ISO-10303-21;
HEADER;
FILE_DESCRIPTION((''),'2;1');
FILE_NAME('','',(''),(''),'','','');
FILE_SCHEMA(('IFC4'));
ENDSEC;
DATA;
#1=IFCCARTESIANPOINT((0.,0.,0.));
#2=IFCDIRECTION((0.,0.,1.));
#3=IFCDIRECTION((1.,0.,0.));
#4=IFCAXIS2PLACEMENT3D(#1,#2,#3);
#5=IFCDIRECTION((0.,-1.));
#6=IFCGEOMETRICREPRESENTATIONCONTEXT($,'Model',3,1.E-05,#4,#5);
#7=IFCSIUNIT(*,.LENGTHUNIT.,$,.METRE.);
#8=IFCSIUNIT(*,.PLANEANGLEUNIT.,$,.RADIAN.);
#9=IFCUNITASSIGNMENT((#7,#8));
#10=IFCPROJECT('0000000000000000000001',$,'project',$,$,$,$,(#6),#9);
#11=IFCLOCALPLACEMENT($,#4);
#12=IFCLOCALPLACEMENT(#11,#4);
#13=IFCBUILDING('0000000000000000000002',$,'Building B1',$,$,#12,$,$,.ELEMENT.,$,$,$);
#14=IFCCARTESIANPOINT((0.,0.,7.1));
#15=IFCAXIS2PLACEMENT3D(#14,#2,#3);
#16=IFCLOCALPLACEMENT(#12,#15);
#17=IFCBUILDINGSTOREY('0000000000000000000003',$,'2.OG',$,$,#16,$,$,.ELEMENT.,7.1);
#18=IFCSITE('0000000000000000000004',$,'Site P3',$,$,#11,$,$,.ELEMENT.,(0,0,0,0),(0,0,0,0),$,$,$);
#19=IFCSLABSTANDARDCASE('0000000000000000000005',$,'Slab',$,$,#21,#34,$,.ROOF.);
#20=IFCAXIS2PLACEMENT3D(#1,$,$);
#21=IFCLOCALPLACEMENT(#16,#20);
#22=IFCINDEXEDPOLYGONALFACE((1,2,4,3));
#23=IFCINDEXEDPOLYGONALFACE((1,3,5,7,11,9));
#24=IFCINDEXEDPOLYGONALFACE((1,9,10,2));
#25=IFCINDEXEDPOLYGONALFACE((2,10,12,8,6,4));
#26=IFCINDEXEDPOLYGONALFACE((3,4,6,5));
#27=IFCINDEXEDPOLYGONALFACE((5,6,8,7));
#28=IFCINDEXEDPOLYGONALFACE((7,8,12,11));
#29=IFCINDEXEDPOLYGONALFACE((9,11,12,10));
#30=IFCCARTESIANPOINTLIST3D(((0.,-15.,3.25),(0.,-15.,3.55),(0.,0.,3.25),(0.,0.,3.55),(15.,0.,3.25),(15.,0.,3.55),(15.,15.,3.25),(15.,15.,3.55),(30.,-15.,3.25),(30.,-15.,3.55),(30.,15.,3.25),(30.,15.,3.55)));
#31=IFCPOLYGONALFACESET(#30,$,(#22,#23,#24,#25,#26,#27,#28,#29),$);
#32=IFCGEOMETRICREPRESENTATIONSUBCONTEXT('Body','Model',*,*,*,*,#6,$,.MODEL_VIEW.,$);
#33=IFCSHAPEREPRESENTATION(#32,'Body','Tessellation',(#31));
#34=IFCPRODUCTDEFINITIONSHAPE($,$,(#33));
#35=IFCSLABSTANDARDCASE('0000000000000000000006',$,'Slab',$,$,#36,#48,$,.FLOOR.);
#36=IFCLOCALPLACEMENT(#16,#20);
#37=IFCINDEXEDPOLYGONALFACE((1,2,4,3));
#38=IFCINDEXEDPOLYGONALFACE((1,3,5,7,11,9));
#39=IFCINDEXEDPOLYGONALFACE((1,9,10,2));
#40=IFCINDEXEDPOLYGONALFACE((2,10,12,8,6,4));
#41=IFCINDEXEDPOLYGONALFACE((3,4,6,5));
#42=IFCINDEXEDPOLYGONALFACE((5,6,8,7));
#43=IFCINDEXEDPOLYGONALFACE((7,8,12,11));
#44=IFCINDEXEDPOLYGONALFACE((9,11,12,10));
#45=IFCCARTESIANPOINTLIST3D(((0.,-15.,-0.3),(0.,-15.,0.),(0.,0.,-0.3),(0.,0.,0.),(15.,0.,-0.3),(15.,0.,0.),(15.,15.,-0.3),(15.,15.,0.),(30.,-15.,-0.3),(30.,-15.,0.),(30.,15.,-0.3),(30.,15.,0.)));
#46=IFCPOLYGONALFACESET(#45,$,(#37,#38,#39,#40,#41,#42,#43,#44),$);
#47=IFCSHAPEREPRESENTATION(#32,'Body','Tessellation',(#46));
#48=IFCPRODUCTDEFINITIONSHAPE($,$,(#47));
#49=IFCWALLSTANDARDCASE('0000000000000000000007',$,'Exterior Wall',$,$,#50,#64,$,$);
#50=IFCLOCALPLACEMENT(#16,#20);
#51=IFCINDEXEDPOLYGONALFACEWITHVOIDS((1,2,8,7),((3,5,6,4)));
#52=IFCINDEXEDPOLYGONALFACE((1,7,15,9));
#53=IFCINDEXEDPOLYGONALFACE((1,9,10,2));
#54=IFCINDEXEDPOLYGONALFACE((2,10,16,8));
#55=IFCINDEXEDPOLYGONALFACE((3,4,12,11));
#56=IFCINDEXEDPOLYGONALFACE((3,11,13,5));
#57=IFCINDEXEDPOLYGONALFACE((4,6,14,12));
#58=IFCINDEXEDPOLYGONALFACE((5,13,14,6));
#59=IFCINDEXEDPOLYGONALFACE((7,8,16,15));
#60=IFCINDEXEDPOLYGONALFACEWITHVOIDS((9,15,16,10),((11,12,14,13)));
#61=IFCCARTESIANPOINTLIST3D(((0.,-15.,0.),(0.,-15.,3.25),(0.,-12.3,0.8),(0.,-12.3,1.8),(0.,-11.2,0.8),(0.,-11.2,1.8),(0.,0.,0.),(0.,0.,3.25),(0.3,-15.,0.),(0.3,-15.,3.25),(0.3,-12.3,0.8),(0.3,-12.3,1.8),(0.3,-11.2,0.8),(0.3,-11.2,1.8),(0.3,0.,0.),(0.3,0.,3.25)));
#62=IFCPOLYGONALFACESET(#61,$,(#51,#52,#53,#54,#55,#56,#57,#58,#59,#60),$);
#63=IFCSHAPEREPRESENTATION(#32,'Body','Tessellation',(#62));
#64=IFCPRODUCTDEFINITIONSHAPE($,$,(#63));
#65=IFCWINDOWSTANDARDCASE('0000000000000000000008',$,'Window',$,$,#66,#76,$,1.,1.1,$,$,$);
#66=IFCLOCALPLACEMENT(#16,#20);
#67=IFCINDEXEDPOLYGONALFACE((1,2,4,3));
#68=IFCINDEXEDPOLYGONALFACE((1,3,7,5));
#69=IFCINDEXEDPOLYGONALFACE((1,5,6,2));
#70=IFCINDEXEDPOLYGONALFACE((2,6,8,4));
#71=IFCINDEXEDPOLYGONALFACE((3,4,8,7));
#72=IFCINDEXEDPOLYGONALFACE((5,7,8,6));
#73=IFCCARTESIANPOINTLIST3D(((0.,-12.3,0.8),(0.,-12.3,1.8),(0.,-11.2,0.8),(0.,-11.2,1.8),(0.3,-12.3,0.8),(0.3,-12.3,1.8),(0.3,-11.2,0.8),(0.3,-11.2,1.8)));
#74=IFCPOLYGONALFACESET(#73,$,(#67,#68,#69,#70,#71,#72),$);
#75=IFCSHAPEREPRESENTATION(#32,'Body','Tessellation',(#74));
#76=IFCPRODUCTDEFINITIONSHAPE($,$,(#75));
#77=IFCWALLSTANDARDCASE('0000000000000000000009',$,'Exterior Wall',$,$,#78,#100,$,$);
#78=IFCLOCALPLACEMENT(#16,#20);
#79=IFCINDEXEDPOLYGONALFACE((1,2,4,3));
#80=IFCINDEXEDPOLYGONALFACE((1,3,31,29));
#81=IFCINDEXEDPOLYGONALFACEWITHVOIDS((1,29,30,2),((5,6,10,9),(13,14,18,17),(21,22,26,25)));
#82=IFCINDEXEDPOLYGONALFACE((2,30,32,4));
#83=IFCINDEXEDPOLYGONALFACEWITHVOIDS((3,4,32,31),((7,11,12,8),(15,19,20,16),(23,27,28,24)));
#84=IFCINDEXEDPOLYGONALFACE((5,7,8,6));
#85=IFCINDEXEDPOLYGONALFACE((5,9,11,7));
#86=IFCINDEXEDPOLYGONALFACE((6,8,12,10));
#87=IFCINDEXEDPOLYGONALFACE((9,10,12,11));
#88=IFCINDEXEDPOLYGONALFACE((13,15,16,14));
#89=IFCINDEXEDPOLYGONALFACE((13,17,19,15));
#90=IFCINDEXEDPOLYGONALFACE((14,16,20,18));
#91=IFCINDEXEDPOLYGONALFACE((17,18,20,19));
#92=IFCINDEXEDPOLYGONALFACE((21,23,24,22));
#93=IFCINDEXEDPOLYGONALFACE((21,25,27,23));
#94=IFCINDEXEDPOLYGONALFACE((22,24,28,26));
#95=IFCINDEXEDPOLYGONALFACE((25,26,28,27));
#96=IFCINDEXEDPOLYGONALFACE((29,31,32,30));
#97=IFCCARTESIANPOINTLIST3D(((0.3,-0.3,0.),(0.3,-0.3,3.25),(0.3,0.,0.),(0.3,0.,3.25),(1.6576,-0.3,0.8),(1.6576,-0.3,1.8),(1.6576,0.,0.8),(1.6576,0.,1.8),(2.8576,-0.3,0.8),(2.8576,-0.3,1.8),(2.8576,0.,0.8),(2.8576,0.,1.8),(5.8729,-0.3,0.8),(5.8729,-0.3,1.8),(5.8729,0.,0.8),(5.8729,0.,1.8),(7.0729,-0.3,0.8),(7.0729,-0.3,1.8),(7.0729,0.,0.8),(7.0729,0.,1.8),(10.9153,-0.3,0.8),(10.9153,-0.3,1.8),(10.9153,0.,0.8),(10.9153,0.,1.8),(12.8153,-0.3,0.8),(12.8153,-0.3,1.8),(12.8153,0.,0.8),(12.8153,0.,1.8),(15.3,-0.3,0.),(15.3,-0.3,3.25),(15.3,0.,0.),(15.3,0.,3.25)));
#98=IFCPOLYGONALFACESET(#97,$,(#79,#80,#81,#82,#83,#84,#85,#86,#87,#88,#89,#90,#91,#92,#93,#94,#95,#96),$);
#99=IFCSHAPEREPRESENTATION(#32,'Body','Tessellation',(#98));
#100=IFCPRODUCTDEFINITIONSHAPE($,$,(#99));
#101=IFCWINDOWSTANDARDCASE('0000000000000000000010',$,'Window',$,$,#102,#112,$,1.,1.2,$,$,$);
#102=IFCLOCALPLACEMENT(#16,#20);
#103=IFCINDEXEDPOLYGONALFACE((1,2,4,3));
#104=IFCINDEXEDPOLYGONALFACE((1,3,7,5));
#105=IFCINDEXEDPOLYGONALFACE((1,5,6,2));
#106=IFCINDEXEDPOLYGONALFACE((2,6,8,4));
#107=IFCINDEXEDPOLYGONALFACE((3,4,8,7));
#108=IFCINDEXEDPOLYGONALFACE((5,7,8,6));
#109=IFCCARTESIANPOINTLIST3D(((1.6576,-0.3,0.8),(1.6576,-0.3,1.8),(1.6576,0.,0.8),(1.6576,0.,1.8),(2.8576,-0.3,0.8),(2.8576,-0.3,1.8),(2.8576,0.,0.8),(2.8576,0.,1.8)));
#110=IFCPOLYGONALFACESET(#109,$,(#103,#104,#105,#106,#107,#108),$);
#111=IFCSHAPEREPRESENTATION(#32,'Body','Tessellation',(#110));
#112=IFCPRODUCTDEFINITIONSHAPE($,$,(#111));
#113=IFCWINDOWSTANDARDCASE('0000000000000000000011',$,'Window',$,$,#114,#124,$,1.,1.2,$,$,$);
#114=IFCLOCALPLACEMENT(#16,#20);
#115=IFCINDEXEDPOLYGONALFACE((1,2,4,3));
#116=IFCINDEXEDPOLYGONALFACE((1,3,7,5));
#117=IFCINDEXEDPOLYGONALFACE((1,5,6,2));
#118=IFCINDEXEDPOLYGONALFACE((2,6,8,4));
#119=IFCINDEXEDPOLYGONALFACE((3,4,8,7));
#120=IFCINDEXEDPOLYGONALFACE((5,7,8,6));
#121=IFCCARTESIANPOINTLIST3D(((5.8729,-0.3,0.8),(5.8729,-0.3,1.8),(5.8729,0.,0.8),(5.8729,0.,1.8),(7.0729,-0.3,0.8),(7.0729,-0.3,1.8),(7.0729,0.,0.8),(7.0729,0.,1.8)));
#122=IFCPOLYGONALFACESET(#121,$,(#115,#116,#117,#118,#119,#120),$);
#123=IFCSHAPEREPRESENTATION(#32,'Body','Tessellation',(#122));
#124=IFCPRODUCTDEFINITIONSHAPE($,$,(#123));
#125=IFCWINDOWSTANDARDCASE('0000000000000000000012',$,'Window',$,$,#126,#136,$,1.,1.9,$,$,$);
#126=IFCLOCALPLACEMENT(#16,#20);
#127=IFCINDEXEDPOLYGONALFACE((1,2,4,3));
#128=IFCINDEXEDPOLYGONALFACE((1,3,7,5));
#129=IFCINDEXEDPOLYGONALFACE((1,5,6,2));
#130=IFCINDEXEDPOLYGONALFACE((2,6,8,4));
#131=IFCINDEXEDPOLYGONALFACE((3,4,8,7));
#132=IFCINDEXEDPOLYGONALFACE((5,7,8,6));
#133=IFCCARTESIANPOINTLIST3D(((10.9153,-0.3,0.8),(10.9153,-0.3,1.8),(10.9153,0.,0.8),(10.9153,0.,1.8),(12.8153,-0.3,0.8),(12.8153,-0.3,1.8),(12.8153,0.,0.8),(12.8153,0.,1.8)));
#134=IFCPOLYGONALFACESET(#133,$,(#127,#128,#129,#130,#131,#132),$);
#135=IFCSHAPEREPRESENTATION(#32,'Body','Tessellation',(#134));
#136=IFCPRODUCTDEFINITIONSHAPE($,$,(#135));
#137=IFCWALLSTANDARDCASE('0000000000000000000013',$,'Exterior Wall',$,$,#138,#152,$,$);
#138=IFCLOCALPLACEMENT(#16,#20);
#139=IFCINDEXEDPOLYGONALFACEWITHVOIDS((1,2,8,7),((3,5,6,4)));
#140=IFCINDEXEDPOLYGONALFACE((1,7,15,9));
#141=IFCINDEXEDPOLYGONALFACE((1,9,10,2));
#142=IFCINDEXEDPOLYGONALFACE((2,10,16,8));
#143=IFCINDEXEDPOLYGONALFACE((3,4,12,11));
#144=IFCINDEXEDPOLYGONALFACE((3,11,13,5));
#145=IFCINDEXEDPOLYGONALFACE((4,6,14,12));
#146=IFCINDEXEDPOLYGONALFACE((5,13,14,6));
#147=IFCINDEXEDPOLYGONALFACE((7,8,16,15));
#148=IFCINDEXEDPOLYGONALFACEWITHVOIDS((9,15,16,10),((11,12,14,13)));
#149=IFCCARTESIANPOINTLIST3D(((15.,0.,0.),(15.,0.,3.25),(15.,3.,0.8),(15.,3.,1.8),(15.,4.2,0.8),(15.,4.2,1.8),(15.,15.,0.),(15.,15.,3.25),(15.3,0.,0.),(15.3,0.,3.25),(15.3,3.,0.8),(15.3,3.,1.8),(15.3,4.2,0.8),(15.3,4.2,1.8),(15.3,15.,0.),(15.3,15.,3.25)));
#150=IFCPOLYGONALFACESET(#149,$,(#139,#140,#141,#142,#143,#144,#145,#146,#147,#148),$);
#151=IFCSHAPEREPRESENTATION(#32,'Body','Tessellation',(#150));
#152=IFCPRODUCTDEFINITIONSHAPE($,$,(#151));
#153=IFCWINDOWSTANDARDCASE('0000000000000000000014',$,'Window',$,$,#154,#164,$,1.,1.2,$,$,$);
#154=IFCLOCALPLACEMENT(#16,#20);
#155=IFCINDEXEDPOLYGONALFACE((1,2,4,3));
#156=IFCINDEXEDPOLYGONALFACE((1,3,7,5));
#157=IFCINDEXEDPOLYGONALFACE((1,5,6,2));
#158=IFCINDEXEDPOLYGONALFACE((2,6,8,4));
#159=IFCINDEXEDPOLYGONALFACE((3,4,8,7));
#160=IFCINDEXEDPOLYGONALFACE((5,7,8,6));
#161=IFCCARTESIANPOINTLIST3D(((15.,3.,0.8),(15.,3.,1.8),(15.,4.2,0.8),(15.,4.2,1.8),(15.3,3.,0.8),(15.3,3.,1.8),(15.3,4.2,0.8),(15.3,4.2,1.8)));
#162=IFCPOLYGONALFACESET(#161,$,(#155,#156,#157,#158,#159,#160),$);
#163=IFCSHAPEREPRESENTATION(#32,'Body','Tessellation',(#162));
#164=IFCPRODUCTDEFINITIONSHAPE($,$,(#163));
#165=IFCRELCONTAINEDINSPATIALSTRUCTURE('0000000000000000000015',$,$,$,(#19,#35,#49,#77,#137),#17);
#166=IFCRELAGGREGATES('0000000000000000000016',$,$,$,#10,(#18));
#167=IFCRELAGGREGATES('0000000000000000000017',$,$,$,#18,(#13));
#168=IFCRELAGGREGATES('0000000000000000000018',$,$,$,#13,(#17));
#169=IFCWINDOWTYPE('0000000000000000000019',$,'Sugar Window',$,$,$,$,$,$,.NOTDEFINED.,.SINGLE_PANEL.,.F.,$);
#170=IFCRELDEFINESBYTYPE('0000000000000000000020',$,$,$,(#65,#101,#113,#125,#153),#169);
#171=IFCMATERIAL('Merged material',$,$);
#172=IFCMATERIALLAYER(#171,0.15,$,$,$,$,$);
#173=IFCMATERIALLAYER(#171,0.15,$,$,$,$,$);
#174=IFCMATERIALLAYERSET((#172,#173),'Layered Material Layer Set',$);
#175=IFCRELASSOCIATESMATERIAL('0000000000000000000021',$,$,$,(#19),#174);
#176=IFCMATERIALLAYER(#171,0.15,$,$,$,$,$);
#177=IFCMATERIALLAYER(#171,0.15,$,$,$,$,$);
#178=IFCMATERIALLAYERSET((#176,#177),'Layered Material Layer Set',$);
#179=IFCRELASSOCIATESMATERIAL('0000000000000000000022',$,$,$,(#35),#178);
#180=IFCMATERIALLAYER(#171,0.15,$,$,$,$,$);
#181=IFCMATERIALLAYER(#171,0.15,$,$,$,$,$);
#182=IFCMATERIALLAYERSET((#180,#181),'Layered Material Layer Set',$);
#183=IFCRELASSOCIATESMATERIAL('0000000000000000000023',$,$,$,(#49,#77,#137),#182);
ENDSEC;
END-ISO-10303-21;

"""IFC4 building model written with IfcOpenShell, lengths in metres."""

from ifc_helpers import new_model, si_unit, direction, frame, origin_with_axes, place, context, subcontext, project, spatial, polyline, outline, extrude, source, transform, mapped, material, layer, layer_set, layer_usage, type_object, element, fill, save


model = new_model("IFC4")

# Units and contexts
model_context = context("Model", 3, precision=1e-05, world=origin_with_axes(), true_north=direction((0.0, -1.0)))
body_context = subcontext(model_context, "Body", "Model", "MODEL_VIEW")
ifc_project = project(units=[si_unit("LENGTHUNIT", "METRE"), si_unit("PLANEANGLEUNIT", "RADIAN")], contexts=[model_context])

# Site, building, storey
site_placement = place(None, origin_with_axes())
site = spatial("IfcSite", under=ifc_project, at=site_placement, Name="Site P3", CompositionType="ELEMENT", RefLatitude=(0, 0, 0, 0), RefLongitude=(0, 0, 0, 0))
building_placement = place(site_placement, origin_with_axes())
building = spatial("IfcBuilding", under=site, at=building_placement, Name="Building B1", CompositionType="ELEMENT")
storey_placement = place(building_placement, frame((0.0, 0.0, 7.1), z_axis=(0.0, 0.0, 1.0), x_axis=(1.0, 0.0, 0.0)))
storey = spatial("IfcBuildingStorey", under=building, at=storey_placement, Name="2.OG", CompositionType="ELEMENT", Elevation=7.1)

# Slabs
ifc_material = material(Name="Merged material")
ifc_layer_1 = layer(ifc_material, 0.15)
ifc_layer_2 = layer(ifc_material, 0.15)
ifc_layer_set_1 = layer_set([ifc_layer_1, ifc_layer_2], Name="Layered Material Layer Set")
ifc_layer_usage_1 = layer_usage(ifc_layer_set_1, "AXIS2", "POSITIVE", -0.15)
slab_1_placement = place(storey_placement, frame((0.0, 0.0, 3.55), z_axis=(0.0, 0.0, 1.0), x_axis=(1.0, 0.0, 0.0)))
element("IfcSlabStandardCase", 1, at=slab_1_placement, inside=storey, material=ifc_layer_usage_1, Name="Slab", PredefinedType="ROOF", context=body_context, shape_type="SweptSolid", body=[
    extrude(outline(polyline([(0.0, -15.0), (30.0, -15.0), (30.0, 15.0), (15.0, 15.0), (15.0, 0.0), (0.0, 0.0), (0.0, -15.0)])), frame((0.0, 0.0, -0.3), z_axis=(0.0, 0.0, 1.0), x_axis=(1.0, 0.0, 0.0)), (0.0, 0.0, 1.0), 0.3),
])
ifc_layer_3 = layer(ifc_material, 0.15)
ifc_layer_4 = layer(ifc_material, 0.15)
ifc_layer_set_2 = layer_set([ifc_layer_3, ifc_layer_4], Name="Layered Material Layer Set")
ifc_layer_usage_2 = layer_usage(ifc_layer_set_2, "AXIS2", "POSITIVE", -0.15)
slab_2_placement = place(storey_placement, origin_with_axes())
element("IfcSlabStandardCase", 2, at=slab_2_placement, inside=storey, material=ifc_layer_usage_2, Name="Slab", PredefinedType="FLOOR", context=body_context, shape_type="SweptSolid", body=[
    extrude(outline(polyline([(0.0, -15.0), (30.0, -15.0), (30.0, 15.0), (15.0, 15.0), (15.0, 0.0), (0.0, 0.0), (0.0, -15.0)])), frame((0.0, 0.0, -0.3), z_axis=(0.0, 0.0, 1.0), x_axis=(1.0, 0.0, 0.0)), (0.0, 0.0, 1.0), 0.3),
])

# Wall, opening, window
ifc_layer_5 = layer(ifc_material, 0.15)
ifc_layer_6 = layer(ifc_material, 0.15)
ifc_layer_set_3 = layer_set([ifc_layer_5, ifc_layer_6], Name="Layered Material Layer Set")
ifc_layer_usage_3 = layer_usage(ifc_layer_set_3, "AXIS2", "POSITIVE", -0.15)
wall_1_placement = place(storey_placement, frame((0.15, 0.0, 0.0), z_axis=(0.0, 0.0, 1.0), x_axis=(0.0, -1.0, 0.0)))
wall_1 = element("IfcWallStandardCase", 3, at=wall_1_placement, inside=storey, material=ifc_layer_usage_3, Name="Exterior Wall", context=body_context, shape_type="SweptSolid", body=[
    extrude(outline(polyline([(0.0, 0.15), (15.0, 0.15), (15.0, -0.15), (0.0, -0.15), (0.0, 0.15)])), origin_with_axes(), (0.0, 0.0, 1.0), 3.25),
])
opening_1_placement = place(wall_1_placement, frame((11.2, 0.0, 0.8), z_axis=(0.0, 0.0, 1.0), x_axis=(1.0, 0.0, 0.0)))
opening_1 = element("IfcOpeningStandardCase", 4, at=opening_1_placement, cuts=wall_1, context=body_context, shape_type="SweptSolid", body=[
    extrude(outline(polyline([(0.0, 0.0), (0.0, 1.1), (1.0, 1.1), (1.0, 0.0), (0.0, 0.0)])), frame((0.0, -0.15, 0.0), z_axis=(0.0, 1.0, 0.0), x_axis=(0.0, 0.0, 1.0)), (0.0, 0.0, 1.0), 0.3),
])
window_type = type_object("IfcWindowType", Name="Sugar Window", ParameterTakesPrecedence=False, PartitioningType="SINGLE_PANEL", PredefinedType="NOTDEFINED")
shared_shape_1 = source(origin_with_axes(), body_context, "Body", "SweptSolid", [
    extrude(outline(polyline([(0.0, 0.0), (0.0, 1.1), (1.0, 1.1), (1.0, 0.0), (0.0, 0.0)])), frame((0.0, -0.15, 0.0), z_axis=(0.0, 1.0, 0.0), x_axis=(0.0, 0.0, 1.0)), (0.0, 0.0, 1.0), 0.3),
])
window_1_placement = place(opening_1_placement, origin_with_axes())
window_1 = element("IfcWindowStandardCase", 5, at=window_1_placement, type_object=window_type, Name="Window", OverallHeight=1.0, OverallWidth=1.1, context=body_context, shape_type="MappedRepresentation", body=[
    mapped(shared_shape_1, transform((0.0, 0.0, 0.0))),
])
fill(opening_1, window_1)

# Wall, openings, windows
wall_2_placement = place(storey_placement, frame((15.3, -0.15, 0.0), z_axis=(0.0, 0.0, 1.0), x_axis=(-1.0, 0.0, 0.0)))
wall_2 = element("IfcWallStandardCase", 6, at=wall_2_placement, inside=storey, material=ifc_layer_usage_3, Name="Exterior Wall", context=body_context, shape_type="SweptSolid", body=[
    extrude(outline(polyline([(0.0, 0.15), (15.0, 0.15), (15.0, -0.15), (0.0, -0.15), (0.0, 0.15)])), origin_with_axes(), (0.0, 0.0, 1.0), 3.25),
])
opening_2_placement = place(wall_2_placement, frame((12.4424, 0.0, 0.8), z_axis=(0.0, 0.0, 1.0), x_axis=(1.0, 0.0, 0.0)))
opening_2 = element("IfcOpeningStandardCase", 7, at=opening_2_placement, cuts=wall_2, context=body_context, shape_type="SweptSolid", body=[
    extrude(outline(polyline([(0.0, 0.0), (0.0, 1.2), (1.0, 1.2), (1.0, 0.0), (0.0, 0.0)])), frame((0.0, -0.15, 0.0), z_axis=(0.0, 1.0, 0.0), x_axis=(0.0, 0.0, 1.0)), (0.0, 0.0, 1.0), 0.3),
])
opening_3_placement = place(wall_2_placement, frame((8.2271, 0.0, 0.8), z_axis=(0.0, 0.0, 1.0), x_axis=(1.0, 0.0, 0.0)))
opening_3 = element("IfcOpeningStandardCase", 8, at=opening_3_placement, cuts=wall_2, context=body_context, shape_type="SweptSolid", body=[
    extrude(outline(polyline([(0.0, 0.0), (0.0, 1.2), (1.0, 1.2), (1.0, 0.0), (0.0, 0.0)])), frame((0.0, -0.15, 0.0), z_axis=(0.0, 1.0, 0.0), x_axis=(0.0, 0.0, 1.0)), (0.0, 0.0, 1.0), 0.3),
])
opening_4_placement = place(wall_2_placement, frame((2.4847, 0.0, 0.8), z_axis=(0.0, 0.0, 1.0), x_axis=(1.0, 0.0, 0.0)))
opening_4 = element("IfcOpeningStandardCase", 9, at=opening_4_placement, cuts=wall_2, context=body_context, shape_type="SweptSolid", body=[
    extrude(outline(polyline([(0.0, 0.0), (0.0, 1.9), (1.0, 1.9), (1.0, 0.0), (0.0, 0.0)])), frame((0.0, -0.15, 0.0), z_axis=(0.0, 1.0, 0.0), x_axis=(0.0, 0.0, 1.0)), (0.0, 0.0, 1.0), 0.3),
])
shared_shape_2 = source(origin_with_axes(), body_context, "Body", "SweptSolid", [
    extrude(outline(polyline([(0.0, 0.0), (0.0, 1.2), (1.0, 1.2), (1.0, 0.0), (0.0, 0.0)])), frame((0.0, -0.15, 0.0), z_axis=(0.0, 1.0, 0.0), x_axis=(0.0, 0.0, 1.0)), (0.0, 0.0, 1.0), 0.3),
])
window_2_placement = place(opening_2_placement, origin_with_axes())
window_2 = element("IfcWindowStandardCase", 10, at=window_2_placement, type_object=window_type, Name="Window", OverallHeight=1.0, OverallWidth=1.2, context=body_context, shape_type="MappedRepresentation", body=[
    mapped(shared_shape_2, transform((0.0, 0.0, 0.0))),
])
fill(opening_2, window_2)
window_3_placement = place(opening_3_placement, origin_with_axes())
window_3 = element("IfcWindowStandardCase", 11, at=window_3_placement, type_object=window_type, Name="Window", OverallHeight=1.0, OverallWidth=1.2, context=body_context, shape_type="MappedRepresentation", body=[
    mapped(shared_shape_2, transform((0.0, 0.0, 0.0))),
])
fill(opening_3, window_3)
shared_shape_3 = source(origin_with_axes(), body_context, "Body", "SweptSolid", [
    extrude(outline(polyline([(0.0, 0.0), (0.0, 1.9), (1.0, 1.9), (1.0, 0.0), (0.0, 0.0)])), frame((0.0, -0.15, 0.0), z_axis=(0.0, 1.0, 0.0), x_axis=(0.0, 0.0, 1.0)), (0.0, 0.0, 1.0), 0.3),
])
window_4_placement = place(opening_4_placement, origin_with_axes())
window_4 = element("IfcWindowStandardCase", 12, at=window_4_placement, type_object=window_type, Name="Window", OverallHeight=1.0, OverallWidth=1.9, context=body_context, shape_type="MappedRepresentation", body=[
    mapped(shared_shape_3, transform((0.0, 0.0, 0.0))),
])
fill(opening_4, window_4)

# Wall, opening, window
wall_3_placement = place(storey_placement, frame((15.15, 15.0, 0.0), z_axis=(0.0, 0.0, 1.0), x_axis=(0.0, -1.0, 0.0)))
wall_3 = element("IfcWallStandardCase", 13, at=wall_3_placement, inside=storey, material=ifc_layer_usage_3, Name="Exterior Wall", context=body_context, shape_type="SweptSolid", body=[
    extrude(outline(polyline([(0.0, 0.15), (15.0, 0.15), (15.0, -0.15), (0.0, -0.15), (0.0, 0.15)])), origin_with_axes(), (0.0, 0.0, 1.0), 3.25),
])
opening_5_placement = place(wall_3_placement, frame((10.8, 0.0, 0.8), z_axis=(0.0, 0.0, 1.0), x_axis=(1.0, 0.0, 0.0)))
opening_5 = element("IfcOpeningStandardCase", 14, at=opening_5_placement, cuts=wall_3, context=body_context, shape_type="SweptSolid", body=[
    extrude(outline(polyline([(0.0, 0.0), (0.0, 1.2), (1.0, 1.2), (1.0, 0.0), (0.0, 0.0)])), frame((0.0, -0.15, 0.0), z_axis=(0.0, 1.0, 0.0), x_axis=(0.0, 0.0, 1.0)), (0.0, 0.0, 1.0), 0.3),
])
window_5_placement = place(opening_5_placement, origin_with_axes())
window_5 = element("IfcWindowStandardCase", 15, at=window_5_placement, type_object=window_type, Name="Window", OverallHeight=1.0, OverallWidth=1.2, context=body_context, shape_type="MappedRepresentation", body=[
    mapped(shared_shape_2, transform((0.0, 0.0, 0.0))),
])
fill(opening_5, window_5)

save(model, "model.ifc")
